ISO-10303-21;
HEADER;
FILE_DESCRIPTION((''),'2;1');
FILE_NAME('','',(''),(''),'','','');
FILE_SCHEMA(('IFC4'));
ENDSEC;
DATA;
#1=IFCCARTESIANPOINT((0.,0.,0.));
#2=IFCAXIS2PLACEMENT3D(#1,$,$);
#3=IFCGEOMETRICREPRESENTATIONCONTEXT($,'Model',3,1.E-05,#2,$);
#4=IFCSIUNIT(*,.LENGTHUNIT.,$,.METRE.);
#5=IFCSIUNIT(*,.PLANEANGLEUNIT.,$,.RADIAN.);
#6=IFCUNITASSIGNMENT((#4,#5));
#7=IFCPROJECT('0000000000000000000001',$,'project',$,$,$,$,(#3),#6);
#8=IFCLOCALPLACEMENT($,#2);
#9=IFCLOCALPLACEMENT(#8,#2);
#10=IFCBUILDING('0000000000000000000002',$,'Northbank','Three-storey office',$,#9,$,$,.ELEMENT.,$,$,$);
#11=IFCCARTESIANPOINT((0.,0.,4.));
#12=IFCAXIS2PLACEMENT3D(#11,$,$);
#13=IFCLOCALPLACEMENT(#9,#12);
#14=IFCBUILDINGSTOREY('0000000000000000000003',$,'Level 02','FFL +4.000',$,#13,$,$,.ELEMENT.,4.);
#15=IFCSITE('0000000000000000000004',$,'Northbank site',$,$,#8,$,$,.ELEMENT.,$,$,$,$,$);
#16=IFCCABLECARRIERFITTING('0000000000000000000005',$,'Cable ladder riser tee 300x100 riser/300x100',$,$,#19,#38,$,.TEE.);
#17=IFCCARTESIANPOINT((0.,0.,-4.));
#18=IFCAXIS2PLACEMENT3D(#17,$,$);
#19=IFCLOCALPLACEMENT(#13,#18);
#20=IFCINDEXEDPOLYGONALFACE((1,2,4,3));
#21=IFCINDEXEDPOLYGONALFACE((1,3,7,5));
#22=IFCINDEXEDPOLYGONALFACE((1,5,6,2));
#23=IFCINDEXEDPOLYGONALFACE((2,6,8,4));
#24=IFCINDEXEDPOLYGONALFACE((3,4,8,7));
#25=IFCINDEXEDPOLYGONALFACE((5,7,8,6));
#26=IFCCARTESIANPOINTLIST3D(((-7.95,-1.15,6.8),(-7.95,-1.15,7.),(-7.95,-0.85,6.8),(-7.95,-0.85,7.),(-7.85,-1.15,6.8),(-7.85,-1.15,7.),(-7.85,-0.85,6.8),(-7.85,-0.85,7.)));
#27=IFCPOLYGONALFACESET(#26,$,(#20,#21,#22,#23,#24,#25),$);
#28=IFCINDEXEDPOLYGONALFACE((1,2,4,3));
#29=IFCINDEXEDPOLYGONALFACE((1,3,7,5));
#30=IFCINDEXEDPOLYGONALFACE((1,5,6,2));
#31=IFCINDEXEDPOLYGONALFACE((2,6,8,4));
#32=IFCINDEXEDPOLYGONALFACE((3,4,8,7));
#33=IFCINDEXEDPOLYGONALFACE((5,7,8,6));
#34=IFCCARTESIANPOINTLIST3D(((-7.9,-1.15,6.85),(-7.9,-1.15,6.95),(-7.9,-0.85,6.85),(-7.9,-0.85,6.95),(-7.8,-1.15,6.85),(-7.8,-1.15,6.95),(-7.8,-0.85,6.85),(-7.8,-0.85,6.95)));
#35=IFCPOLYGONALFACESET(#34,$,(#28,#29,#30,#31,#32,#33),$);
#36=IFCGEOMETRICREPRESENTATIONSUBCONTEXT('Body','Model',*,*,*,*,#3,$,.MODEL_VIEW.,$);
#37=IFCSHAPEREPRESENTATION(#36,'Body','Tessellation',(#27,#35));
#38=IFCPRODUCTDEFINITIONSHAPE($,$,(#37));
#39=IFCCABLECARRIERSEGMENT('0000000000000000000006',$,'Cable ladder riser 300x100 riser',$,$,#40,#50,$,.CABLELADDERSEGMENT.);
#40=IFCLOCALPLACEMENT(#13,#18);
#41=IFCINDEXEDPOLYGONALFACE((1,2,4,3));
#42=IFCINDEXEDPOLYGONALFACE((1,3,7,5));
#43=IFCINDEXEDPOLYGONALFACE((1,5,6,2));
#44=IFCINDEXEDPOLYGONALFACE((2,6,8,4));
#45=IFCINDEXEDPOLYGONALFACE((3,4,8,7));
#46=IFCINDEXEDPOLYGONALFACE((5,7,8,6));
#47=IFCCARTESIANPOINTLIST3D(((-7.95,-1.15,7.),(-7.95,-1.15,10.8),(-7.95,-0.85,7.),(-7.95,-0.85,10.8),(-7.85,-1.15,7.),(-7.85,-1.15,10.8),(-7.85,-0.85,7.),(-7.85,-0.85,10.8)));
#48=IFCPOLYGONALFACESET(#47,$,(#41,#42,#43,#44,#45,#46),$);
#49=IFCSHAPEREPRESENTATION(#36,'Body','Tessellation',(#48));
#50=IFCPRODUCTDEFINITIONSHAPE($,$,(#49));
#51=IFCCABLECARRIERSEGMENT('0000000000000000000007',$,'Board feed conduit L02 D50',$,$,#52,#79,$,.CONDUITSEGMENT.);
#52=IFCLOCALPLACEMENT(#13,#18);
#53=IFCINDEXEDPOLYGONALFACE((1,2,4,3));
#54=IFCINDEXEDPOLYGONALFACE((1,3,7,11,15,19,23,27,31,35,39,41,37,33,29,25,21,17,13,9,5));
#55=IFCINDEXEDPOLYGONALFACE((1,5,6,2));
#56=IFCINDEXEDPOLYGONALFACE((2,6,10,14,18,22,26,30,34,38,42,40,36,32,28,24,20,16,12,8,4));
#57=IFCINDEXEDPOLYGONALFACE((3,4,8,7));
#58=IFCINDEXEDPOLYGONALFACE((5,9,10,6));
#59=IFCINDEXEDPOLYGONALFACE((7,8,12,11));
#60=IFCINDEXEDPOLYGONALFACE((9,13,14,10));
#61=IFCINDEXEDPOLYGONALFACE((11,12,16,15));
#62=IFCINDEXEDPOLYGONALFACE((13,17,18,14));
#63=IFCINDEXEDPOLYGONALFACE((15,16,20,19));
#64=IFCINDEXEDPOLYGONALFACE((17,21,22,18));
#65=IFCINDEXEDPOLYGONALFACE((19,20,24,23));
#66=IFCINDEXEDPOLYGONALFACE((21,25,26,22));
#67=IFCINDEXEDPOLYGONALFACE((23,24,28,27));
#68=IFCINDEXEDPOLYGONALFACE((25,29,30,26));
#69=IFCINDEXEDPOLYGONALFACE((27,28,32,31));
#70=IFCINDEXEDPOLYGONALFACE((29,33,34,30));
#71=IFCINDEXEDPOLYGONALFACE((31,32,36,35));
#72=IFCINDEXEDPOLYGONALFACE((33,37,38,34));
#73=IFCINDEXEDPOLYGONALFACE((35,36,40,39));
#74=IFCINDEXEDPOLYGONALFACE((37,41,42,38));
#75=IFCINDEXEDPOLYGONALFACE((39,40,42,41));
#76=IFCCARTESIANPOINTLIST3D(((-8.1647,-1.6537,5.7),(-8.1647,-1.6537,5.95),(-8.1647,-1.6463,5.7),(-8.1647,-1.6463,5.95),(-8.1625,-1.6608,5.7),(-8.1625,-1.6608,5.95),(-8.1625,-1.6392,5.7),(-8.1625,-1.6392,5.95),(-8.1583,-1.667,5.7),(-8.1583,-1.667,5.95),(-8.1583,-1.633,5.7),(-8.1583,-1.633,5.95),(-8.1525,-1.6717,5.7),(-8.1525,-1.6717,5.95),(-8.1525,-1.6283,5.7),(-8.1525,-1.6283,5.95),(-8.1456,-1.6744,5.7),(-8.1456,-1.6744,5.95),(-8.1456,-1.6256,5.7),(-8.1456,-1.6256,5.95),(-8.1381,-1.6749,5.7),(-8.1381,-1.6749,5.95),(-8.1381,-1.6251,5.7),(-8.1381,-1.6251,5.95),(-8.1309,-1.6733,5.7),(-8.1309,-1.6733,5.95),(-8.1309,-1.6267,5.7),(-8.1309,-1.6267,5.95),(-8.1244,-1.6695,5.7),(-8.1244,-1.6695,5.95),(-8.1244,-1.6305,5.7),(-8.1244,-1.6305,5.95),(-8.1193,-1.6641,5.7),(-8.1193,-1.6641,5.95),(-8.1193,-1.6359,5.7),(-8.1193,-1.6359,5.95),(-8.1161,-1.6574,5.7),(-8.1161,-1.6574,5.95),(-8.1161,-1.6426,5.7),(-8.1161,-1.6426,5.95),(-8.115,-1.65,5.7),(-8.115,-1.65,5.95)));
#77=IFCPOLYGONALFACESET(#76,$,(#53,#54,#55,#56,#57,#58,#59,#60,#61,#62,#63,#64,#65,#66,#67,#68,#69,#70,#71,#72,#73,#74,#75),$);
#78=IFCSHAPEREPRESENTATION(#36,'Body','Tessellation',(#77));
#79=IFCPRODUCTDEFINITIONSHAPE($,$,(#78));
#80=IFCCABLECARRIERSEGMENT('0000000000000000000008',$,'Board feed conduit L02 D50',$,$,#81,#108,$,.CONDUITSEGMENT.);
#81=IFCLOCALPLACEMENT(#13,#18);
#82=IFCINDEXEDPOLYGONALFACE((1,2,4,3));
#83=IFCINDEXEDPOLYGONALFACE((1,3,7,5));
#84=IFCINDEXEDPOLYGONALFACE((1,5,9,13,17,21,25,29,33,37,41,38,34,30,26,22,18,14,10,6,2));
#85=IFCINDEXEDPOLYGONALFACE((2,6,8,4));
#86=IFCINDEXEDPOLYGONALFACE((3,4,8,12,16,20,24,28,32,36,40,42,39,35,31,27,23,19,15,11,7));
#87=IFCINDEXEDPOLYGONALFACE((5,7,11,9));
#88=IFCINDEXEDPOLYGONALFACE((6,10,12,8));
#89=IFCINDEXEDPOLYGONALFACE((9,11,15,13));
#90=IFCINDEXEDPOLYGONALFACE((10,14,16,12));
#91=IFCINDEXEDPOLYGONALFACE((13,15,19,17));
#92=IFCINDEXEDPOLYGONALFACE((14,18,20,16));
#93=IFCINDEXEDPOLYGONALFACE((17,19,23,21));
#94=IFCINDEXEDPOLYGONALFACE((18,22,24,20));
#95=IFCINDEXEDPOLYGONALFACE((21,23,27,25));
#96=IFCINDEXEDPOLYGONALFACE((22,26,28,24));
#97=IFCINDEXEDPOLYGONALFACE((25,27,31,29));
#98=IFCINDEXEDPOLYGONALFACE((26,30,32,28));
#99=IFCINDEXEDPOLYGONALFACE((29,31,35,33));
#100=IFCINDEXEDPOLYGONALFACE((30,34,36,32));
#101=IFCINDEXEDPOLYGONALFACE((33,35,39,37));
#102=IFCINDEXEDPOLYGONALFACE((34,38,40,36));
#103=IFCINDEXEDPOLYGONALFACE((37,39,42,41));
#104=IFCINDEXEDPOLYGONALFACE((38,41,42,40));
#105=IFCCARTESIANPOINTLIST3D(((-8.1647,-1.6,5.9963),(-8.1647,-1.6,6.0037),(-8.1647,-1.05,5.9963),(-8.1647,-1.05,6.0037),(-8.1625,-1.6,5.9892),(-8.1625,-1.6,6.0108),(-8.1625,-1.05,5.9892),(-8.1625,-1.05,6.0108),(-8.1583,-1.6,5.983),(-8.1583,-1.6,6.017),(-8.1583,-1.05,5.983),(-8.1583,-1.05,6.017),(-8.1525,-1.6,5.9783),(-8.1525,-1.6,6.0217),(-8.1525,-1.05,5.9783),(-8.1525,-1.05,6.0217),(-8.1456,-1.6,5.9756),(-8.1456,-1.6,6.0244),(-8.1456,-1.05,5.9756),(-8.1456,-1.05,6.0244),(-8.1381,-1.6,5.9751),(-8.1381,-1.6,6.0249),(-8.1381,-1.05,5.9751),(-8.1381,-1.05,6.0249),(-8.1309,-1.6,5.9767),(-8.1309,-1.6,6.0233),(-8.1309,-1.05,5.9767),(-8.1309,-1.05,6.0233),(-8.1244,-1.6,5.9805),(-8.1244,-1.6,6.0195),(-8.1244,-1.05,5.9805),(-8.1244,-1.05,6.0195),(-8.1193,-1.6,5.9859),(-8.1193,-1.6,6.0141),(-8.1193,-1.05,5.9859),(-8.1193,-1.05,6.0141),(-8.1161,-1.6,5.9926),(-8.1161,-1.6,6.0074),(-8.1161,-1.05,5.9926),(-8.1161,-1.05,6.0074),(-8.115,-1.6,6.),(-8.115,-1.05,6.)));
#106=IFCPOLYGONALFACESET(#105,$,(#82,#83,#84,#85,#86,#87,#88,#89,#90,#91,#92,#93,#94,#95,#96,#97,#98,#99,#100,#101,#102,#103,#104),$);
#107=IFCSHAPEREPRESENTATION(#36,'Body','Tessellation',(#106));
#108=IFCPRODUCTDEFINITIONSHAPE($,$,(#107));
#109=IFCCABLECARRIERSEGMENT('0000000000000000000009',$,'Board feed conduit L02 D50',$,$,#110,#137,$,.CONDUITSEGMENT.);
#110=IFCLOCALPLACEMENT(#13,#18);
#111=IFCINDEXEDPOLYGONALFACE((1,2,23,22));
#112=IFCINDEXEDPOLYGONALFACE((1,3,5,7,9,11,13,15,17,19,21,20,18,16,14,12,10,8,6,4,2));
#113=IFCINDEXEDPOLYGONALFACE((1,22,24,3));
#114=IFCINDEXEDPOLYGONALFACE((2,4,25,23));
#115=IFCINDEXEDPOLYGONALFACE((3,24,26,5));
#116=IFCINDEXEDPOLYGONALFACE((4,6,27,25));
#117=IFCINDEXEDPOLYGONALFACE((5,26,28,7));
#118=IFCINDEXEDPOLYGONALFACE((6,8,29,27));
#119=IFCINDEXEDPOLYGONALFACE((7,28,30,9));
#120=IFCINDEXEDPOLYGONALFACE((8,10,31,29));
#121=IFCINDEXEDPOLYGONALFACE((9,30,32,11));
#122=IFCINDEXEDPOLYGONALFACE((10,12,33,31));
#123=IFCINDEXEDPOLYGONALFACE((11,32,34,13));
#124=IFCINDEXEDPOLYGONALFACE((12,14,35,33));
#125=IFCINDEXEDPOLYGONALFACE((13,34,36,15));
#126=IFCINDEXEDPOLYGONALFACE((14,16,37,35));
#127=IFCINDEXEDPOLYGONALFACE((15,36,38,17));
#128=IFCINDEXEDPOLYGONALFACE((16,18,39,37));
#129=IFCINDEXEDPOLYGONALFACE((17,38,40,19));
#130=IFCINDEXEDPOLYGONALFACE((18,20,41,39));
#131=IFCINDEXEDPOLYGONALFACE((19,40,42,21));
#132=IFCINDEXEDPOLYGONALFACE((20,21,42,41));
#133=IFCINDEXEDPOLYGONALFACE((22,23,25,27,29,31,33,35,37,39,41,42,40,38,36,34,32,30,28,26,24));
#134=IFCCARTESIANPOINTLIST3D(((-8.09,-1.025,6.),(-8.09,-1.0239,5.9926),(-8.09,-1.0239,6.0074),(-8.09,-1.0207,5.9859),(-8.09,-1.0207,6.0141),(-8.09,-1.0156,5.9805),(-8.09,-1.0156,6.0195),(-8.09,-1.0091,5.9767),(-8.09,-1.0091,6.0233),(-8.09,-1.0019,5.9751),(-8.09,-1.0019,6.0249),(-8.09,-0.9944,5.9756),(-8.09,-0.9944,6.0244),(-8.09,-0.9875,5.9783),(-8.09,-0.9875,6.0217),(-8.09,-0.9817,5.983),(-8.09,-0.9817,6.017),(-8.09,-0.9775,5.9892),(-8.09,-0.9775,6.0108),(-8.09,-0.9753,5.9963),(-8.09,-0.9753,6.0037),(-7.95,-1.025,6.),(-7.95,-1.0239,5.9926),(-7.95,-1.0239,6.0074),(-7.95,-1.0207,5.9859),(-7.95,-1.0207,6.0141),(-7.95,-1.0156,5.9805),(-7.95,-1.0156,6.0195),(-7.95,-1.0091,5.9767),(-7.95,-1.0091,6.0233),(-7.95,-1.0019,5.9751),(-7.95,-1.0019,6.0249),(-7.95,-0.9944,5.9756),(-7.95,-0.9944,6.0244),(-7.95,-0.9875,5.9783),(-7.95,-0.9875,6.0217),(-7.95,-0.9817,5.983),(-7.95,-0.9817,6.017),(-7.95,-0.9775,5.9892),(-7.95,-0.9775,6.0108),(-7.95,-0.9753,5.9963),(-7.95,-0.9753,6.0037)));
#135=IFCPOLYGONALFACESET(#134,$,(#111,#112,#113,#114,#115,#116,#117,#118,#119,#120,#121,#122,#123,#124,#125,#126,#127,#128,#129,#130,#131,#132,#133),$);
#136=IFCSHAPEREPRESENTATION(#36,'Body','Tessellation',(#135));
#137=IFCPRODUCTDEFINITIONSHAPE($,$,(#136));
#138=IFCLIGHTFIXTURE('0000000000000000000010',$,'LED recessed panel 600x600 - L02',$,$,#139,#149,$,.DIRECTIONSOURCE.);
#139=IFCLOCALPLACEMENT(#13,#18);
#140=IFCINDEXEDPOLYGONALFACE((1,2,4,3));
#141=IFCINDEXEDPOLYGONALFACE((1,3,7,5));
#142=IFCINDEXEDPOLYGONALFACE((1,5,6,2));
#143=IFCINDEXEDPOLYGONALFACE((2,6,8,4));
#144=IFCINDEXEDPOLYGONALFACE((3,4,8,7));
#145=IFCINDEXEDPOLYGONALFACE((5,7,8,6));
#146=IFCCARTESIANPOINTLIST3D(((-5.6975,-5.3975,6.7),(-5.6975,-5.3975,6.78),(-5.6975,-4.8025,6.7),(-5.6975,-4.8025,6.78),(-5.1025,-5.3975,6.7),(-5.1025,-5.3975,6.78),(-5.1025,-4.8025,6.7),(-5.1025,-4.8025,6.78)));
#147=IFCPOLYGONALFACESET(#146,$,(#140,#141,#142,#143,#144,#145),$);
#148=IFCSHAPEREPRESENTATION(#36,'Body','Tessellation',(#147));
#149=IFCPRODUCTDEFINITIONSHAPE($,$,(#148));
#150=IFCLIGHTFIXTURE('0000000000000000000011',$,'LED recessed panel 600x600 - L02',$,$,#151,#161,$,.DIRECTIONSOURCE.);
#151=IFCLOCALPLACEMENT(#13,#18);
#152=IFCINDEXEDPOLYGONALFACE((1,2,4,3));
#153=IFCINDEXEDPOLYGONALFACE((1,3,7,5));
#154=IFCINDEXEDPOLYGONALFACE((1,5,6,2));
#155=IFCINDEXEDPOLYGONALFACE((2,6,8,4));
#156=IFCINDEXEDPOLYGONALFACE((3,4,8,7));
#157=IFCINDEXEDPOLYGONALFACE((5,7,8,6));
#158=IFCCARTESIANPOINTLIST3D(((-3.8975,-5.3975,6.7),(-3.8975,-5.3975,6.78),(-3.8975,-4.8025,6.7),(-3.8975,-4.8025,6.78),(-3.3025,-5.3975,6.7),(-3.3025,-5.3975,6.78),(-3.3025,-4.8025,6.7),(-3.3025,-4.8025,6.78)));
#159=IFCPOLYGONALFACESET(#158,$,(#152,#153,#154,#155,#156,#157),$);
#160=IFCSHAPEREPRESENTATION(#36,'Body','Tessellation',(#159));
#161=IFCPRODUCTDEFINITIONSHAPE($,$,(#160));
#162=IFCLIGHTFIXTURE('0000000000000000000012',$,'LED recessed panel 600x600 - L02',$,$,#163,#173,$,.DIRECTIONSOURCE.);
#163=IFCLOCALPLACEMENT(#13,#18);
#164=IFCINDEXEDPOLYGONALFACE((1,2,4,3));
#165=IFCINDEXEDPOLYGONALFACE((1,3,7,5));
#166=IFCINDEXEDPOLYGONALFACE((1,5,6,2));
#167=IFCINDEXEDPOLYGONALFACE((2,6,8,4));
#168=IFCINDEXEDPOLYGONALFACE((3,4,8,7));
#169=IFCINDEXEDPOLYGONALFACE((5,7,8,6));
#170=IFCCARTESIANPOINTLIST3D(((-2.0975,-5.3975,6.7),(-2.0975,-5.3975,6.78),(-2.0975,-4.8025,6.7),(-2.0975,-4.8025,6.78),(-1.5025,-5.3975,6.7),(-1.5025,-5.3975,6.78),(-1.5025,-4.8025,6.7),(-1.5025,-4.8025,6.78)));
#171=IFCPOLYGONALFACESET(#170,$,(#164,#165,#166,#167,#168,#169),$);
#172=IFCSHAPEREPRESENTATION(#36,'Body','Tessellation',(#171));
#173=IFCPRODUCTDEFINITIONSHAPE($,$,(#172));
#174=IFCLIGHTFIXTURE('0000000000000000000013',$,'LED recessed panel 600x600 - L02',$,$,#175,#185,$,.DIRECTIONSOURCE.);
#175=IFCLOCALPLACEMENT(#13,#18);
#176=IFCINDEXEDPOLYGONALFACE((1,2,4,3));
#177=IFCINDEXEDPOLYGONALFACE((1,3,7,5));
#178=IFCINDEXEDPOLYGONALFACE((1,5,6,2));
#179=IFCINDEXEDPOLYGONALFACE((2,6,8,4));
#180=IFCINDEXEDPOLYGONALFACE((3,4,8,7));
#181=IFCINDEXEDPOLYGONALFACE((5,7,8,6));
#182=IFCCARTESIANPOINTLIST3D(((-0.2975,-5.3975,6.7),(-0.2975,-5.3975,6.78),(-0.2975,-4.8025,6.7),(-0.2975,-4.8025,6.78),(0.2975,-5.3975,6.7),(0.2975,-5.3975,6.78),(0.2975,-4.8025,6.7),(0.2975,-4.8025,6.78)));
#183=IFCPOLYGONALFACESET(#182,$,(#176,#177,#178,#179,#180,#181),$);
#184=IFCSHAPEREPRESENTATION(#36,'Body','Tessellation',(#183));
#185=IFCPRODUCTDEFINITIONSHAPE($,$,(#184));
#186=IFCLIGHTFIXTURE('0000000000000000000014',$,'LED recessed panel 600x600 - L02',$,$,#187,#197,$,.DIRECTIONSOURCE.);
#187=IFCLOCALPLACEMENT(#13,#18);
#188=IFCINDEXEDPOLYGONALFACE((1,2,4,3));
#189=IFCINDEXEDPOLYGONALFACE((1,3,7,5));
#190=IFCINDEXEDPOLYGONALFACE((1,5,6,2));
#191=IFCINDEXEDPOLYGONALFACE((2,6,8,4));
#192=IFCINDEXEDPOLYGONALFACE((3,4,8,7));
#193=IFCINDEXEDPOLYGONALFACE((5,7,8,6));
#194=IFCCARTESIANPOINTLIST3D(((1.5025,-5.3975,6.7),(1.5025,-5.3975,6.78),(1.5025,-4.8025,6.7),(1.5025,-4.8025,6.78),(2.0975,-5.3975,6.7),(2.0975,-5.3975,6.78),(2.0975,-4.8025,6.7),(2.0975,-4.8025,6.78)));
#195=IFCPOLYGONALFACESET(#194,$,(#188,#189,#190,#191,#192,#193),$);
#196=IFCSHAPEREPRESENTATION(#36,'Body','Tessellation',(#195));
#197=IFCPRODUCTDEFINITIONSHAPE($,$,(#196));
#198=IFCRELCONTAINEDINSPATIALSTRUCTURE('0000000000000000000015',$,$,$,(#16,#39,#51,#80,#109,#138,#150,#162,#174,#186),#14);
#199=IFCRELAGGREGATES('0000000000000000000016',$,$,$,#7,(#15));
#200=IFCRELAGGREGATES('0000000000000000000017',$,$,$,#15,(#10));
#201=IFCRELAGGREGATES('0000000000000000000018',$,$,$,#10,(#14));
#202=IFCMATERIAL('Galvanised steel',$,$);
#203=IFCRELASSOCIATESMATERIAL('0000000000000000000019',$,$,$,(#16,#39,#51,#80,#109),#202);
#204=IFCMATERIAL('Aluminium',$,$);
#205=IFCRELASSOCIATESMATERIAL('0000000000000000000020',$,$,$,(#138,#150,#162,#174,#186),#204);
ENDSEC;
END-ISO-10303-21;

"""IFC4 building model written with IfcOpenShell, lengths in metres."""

from ifc_helpers import new_model, si_unit, frame, origin, place, context, subcontext, project, spatial, rectangle, circle, extrude, material, element, save


model = new_model("IFC4")

# Units and contexts
model_context = context("Model", 3, precision=1e-05, world=origin())
body_context = subcontext(model_context, "Body", "Model", "MODEL_VIEW")
ifc_project = project(units=[si_unit("LENGTHUNIT", "METRE"), si_unit("PLANEANGLEUNIT", "RADIAN")], contexts=[model_context])

# Site, building, storey
site_placement = place(None, origin())
site = spatial("IfcSite", under=ifc_project, at=site_placement, Name="Northbank site", CompositionType="ELEMENT")
building_placement = place(site_placement, origin())
building = spatial("IfcBuilding", under=site, at=building_placement, Name="Northbank", Description="Three-storey office", CompositionType="ELEMENT")
storey_placement = place(building_placement, frame((0.0, 0.0, 4.0)))
storey = spatial("IfcBuildingStorey", under=building, at=storey_placement, Name="Level 02", Description="FFL +4.000", CompositionType="ELEMENT", Elevation=4.0)

# Cable carrier fitting
ifc_material_1 = material(Name="Galvanised steel")
cable_carrier_fitting_placement = place(storey_placement, frame((0.0, 0.0, -4.0)))
element("IfcCableCarrierFitting", 1, at=cable_carrier_fitting_placement, inside=storey, material=ifc_material_1, Name="Cable ladder riser tee 300x100 riser/300x100", PredefinedType="TEE", context=body_context, shape_type="SweptSolid", body=[
    extrude(rectangle(XDim=0.1, YDim=0.3), frame((-7.9, -1.0, 6.8), z_axis=(0.0, 0.0, 1.0), x_axis=(1.0, 0.0, 0.0)), (0.0, 0.0, 1.0), 0.2),
    extrude(rectangle(XDim=0.3, YDim=0.1), frame((-7.9, -1.0, 6.9), z_axis=(1.0, 0.0, 0.0), x_axis=(0.0, 1.0, 0.0)), (0.0, 0.0, 1.0), 0.1),
])

# Cable carrier segments
cable_carrier_segment_1_placement = place(storey_placement, frame((0.0, 0.0, -4.0)))
element("IfcCableCarrierSegment", 2, at=cable_carrier_segment_1_placement, inside=storey, material=ifc_material_1, Name="Cable ladder riser 300x100 riser", PredefinedType="CABLELADDERSEGMENT", context=body_context, shape_type="SweptSolid", body=[
    extrude(rectangle(XDim=0.1, YDim=0.3), frame((-7.9, -1.0, 7.0), z_axis=(0.0, 0.0, 1.0), x_axis=(1.0, 0.0, 0.0)), (0.0, 0.0, 1.0), 3.8),
])
cable_carrier_segment_2_placement = place(storey_placement, frame((0.0, 0.0, -4.0)))
element("IfcCableCarrierSegment", 3, at=cable_carrier_segment_2_placement, inside=storey, material=ifc_material_1, Name="Board feed conduit L02 D50", PredefinedType="CONDUITSEGMENT", context=body_context, shape_type="SweptSolid", body=[
    extrude(circle(Radius=0.025), frame((-8.14, -1.65, 5.7), z_axis=(0.0, 0.0, 1.0), x_axis=(1.0, 0.0, 0.0)), (0.0, 0.0, 1.0), 0.25),
])
cable_carrier_segment_3_placement = place(storey_placement, frame((0.0, 0.0, -4.0)))
element("IfcCableCarrierSegment", 4, at=cable_carrier_segment_3_placement, inside=storey, material=ifc_material_1, Name="Board feed conduit L02 D50", PredefinedType="CONDUITSEGMENT", context=body_context, shape_type="SweptSolid", body=[
    extrude(circle(Radius=0.025), frame((-8.14, -1.6, 6.0), z_axis=(0.0, 1.0, 0.0), x_axis=(1.0, 0.0, 0.0)), (0.0, 0.0, 1.0), 0.55),
])
cable_carrier_segment_4_placement = place(storey_placement, frame((0.0, 0.0, -4.0)))
element("IfcCableCarrierSegment", 5, at=cable_carrier_segment_4_placement, inside=storey, material=ifc_material_1, Name="Board feed conduit L02 D50", PredefinedType="CONDUITSEGMENT", context=body_context, shape_type="SweptSolid", body=[
    extrude(circle(Radius=0.025), frame((-8.09, -1.0, 6.0), z_axis=(1.0, 0.0, 0.0), x_axis=(0.0, -1.0, 0.0)), (0.0, 0.0, 1.0), 0.14),
])

# Light fixtures
ifc_material_2 = material(Name="Aluminium")
light_fixture_1_placement = place(storey_placement, frame((0.0, 0.0, -4.0)))
element("IfcLightFixture", 6, at=light_fixture_1_placement, inside=storey, material=ifc_material_2, Name="LED recessed panel 600x600 - L02", PredefinedType="DIRECTIONSOURCE", context=body_context, shape_type="SweptSolid", body=[
    extrude(rectangle(XDim=0.595, YDim=0.595), frame((-5.4, -5.1, 6.7)), (0.0, 0.0, 1.0), 0.08),
])
light_fixture_2_placement = place(storey_placement, frame((0.0, 0.0, -4.0)))
element("IfcLightFixture", 7, at=light_fixture_2_placement, inside=storey, material=ifc_material_2, Name="LED recessed panel 600x600 - L02", PredefinedType="DIRECTIONSOURCE", context=body_context, shape_type="SweptSolid", body=[
    extrude(rectangle(XDim=0.595, YDim=0.595), frame((-3.6, -5.1, 6.7)), (0.0, 0.0, 1.0), 0.08),
])
light_fixture_3_placement = place(storey_placement, frame((0.0, 0.0, -4.0)))
element("IfcLightFixture", 8, at=light_fixture_3_placement, inside=storey, material=ifc_material_2, Name="LED recessed panel 600x600 - L02", PredefinedType="DIRECTIONSOURCE", context=body_context, shape_type="SweptSolid", body=[
    extrude(rectangle(XDim=0.595, YDim=0.595), frame((-1.8, -5.1, 6.7)), (0.0, 0.0, 1.0), 0.08),
])
light_fixture_4_placement = place(storey_placement, frame((0.0, 0.0, -4.0)))
element("IfcLightFixture", 9, at=light_fixture_4_placement, inside=storey, material=ifc_material_2, Name="LED recessed panel 600x600 - L02", PredefinedType="DIRECTIONSOURCE", context=body_context, shape_type="SweptSolid", body=[
    extrude(rectangle(XDim=0.595, YDim=0.595), frame((0.0, -5.1, 6.7)), (0.0, 0.0, 1.0), 0.08),
])
light_fixture_5_placement = place(storey_placement, frame((0.0, 0.0, -4.0)))
element("IfcLightFixture", 10, at=light_fixture_5_placement, inside=storey, material=ifc_material_2, Name="LED recessed panel 600x600 - L02", PredefinedType="DIRECTIONSOURCE", context=body_context, shape_type="SweptSolid", body=[
    extrude(rectangle(XDim=0.595, YDim=0.595), frame((1.8, -5.1, 6.7)), (0.0, 0.0, 1.0), 0.08),
])

save(model, "model.ifc")
